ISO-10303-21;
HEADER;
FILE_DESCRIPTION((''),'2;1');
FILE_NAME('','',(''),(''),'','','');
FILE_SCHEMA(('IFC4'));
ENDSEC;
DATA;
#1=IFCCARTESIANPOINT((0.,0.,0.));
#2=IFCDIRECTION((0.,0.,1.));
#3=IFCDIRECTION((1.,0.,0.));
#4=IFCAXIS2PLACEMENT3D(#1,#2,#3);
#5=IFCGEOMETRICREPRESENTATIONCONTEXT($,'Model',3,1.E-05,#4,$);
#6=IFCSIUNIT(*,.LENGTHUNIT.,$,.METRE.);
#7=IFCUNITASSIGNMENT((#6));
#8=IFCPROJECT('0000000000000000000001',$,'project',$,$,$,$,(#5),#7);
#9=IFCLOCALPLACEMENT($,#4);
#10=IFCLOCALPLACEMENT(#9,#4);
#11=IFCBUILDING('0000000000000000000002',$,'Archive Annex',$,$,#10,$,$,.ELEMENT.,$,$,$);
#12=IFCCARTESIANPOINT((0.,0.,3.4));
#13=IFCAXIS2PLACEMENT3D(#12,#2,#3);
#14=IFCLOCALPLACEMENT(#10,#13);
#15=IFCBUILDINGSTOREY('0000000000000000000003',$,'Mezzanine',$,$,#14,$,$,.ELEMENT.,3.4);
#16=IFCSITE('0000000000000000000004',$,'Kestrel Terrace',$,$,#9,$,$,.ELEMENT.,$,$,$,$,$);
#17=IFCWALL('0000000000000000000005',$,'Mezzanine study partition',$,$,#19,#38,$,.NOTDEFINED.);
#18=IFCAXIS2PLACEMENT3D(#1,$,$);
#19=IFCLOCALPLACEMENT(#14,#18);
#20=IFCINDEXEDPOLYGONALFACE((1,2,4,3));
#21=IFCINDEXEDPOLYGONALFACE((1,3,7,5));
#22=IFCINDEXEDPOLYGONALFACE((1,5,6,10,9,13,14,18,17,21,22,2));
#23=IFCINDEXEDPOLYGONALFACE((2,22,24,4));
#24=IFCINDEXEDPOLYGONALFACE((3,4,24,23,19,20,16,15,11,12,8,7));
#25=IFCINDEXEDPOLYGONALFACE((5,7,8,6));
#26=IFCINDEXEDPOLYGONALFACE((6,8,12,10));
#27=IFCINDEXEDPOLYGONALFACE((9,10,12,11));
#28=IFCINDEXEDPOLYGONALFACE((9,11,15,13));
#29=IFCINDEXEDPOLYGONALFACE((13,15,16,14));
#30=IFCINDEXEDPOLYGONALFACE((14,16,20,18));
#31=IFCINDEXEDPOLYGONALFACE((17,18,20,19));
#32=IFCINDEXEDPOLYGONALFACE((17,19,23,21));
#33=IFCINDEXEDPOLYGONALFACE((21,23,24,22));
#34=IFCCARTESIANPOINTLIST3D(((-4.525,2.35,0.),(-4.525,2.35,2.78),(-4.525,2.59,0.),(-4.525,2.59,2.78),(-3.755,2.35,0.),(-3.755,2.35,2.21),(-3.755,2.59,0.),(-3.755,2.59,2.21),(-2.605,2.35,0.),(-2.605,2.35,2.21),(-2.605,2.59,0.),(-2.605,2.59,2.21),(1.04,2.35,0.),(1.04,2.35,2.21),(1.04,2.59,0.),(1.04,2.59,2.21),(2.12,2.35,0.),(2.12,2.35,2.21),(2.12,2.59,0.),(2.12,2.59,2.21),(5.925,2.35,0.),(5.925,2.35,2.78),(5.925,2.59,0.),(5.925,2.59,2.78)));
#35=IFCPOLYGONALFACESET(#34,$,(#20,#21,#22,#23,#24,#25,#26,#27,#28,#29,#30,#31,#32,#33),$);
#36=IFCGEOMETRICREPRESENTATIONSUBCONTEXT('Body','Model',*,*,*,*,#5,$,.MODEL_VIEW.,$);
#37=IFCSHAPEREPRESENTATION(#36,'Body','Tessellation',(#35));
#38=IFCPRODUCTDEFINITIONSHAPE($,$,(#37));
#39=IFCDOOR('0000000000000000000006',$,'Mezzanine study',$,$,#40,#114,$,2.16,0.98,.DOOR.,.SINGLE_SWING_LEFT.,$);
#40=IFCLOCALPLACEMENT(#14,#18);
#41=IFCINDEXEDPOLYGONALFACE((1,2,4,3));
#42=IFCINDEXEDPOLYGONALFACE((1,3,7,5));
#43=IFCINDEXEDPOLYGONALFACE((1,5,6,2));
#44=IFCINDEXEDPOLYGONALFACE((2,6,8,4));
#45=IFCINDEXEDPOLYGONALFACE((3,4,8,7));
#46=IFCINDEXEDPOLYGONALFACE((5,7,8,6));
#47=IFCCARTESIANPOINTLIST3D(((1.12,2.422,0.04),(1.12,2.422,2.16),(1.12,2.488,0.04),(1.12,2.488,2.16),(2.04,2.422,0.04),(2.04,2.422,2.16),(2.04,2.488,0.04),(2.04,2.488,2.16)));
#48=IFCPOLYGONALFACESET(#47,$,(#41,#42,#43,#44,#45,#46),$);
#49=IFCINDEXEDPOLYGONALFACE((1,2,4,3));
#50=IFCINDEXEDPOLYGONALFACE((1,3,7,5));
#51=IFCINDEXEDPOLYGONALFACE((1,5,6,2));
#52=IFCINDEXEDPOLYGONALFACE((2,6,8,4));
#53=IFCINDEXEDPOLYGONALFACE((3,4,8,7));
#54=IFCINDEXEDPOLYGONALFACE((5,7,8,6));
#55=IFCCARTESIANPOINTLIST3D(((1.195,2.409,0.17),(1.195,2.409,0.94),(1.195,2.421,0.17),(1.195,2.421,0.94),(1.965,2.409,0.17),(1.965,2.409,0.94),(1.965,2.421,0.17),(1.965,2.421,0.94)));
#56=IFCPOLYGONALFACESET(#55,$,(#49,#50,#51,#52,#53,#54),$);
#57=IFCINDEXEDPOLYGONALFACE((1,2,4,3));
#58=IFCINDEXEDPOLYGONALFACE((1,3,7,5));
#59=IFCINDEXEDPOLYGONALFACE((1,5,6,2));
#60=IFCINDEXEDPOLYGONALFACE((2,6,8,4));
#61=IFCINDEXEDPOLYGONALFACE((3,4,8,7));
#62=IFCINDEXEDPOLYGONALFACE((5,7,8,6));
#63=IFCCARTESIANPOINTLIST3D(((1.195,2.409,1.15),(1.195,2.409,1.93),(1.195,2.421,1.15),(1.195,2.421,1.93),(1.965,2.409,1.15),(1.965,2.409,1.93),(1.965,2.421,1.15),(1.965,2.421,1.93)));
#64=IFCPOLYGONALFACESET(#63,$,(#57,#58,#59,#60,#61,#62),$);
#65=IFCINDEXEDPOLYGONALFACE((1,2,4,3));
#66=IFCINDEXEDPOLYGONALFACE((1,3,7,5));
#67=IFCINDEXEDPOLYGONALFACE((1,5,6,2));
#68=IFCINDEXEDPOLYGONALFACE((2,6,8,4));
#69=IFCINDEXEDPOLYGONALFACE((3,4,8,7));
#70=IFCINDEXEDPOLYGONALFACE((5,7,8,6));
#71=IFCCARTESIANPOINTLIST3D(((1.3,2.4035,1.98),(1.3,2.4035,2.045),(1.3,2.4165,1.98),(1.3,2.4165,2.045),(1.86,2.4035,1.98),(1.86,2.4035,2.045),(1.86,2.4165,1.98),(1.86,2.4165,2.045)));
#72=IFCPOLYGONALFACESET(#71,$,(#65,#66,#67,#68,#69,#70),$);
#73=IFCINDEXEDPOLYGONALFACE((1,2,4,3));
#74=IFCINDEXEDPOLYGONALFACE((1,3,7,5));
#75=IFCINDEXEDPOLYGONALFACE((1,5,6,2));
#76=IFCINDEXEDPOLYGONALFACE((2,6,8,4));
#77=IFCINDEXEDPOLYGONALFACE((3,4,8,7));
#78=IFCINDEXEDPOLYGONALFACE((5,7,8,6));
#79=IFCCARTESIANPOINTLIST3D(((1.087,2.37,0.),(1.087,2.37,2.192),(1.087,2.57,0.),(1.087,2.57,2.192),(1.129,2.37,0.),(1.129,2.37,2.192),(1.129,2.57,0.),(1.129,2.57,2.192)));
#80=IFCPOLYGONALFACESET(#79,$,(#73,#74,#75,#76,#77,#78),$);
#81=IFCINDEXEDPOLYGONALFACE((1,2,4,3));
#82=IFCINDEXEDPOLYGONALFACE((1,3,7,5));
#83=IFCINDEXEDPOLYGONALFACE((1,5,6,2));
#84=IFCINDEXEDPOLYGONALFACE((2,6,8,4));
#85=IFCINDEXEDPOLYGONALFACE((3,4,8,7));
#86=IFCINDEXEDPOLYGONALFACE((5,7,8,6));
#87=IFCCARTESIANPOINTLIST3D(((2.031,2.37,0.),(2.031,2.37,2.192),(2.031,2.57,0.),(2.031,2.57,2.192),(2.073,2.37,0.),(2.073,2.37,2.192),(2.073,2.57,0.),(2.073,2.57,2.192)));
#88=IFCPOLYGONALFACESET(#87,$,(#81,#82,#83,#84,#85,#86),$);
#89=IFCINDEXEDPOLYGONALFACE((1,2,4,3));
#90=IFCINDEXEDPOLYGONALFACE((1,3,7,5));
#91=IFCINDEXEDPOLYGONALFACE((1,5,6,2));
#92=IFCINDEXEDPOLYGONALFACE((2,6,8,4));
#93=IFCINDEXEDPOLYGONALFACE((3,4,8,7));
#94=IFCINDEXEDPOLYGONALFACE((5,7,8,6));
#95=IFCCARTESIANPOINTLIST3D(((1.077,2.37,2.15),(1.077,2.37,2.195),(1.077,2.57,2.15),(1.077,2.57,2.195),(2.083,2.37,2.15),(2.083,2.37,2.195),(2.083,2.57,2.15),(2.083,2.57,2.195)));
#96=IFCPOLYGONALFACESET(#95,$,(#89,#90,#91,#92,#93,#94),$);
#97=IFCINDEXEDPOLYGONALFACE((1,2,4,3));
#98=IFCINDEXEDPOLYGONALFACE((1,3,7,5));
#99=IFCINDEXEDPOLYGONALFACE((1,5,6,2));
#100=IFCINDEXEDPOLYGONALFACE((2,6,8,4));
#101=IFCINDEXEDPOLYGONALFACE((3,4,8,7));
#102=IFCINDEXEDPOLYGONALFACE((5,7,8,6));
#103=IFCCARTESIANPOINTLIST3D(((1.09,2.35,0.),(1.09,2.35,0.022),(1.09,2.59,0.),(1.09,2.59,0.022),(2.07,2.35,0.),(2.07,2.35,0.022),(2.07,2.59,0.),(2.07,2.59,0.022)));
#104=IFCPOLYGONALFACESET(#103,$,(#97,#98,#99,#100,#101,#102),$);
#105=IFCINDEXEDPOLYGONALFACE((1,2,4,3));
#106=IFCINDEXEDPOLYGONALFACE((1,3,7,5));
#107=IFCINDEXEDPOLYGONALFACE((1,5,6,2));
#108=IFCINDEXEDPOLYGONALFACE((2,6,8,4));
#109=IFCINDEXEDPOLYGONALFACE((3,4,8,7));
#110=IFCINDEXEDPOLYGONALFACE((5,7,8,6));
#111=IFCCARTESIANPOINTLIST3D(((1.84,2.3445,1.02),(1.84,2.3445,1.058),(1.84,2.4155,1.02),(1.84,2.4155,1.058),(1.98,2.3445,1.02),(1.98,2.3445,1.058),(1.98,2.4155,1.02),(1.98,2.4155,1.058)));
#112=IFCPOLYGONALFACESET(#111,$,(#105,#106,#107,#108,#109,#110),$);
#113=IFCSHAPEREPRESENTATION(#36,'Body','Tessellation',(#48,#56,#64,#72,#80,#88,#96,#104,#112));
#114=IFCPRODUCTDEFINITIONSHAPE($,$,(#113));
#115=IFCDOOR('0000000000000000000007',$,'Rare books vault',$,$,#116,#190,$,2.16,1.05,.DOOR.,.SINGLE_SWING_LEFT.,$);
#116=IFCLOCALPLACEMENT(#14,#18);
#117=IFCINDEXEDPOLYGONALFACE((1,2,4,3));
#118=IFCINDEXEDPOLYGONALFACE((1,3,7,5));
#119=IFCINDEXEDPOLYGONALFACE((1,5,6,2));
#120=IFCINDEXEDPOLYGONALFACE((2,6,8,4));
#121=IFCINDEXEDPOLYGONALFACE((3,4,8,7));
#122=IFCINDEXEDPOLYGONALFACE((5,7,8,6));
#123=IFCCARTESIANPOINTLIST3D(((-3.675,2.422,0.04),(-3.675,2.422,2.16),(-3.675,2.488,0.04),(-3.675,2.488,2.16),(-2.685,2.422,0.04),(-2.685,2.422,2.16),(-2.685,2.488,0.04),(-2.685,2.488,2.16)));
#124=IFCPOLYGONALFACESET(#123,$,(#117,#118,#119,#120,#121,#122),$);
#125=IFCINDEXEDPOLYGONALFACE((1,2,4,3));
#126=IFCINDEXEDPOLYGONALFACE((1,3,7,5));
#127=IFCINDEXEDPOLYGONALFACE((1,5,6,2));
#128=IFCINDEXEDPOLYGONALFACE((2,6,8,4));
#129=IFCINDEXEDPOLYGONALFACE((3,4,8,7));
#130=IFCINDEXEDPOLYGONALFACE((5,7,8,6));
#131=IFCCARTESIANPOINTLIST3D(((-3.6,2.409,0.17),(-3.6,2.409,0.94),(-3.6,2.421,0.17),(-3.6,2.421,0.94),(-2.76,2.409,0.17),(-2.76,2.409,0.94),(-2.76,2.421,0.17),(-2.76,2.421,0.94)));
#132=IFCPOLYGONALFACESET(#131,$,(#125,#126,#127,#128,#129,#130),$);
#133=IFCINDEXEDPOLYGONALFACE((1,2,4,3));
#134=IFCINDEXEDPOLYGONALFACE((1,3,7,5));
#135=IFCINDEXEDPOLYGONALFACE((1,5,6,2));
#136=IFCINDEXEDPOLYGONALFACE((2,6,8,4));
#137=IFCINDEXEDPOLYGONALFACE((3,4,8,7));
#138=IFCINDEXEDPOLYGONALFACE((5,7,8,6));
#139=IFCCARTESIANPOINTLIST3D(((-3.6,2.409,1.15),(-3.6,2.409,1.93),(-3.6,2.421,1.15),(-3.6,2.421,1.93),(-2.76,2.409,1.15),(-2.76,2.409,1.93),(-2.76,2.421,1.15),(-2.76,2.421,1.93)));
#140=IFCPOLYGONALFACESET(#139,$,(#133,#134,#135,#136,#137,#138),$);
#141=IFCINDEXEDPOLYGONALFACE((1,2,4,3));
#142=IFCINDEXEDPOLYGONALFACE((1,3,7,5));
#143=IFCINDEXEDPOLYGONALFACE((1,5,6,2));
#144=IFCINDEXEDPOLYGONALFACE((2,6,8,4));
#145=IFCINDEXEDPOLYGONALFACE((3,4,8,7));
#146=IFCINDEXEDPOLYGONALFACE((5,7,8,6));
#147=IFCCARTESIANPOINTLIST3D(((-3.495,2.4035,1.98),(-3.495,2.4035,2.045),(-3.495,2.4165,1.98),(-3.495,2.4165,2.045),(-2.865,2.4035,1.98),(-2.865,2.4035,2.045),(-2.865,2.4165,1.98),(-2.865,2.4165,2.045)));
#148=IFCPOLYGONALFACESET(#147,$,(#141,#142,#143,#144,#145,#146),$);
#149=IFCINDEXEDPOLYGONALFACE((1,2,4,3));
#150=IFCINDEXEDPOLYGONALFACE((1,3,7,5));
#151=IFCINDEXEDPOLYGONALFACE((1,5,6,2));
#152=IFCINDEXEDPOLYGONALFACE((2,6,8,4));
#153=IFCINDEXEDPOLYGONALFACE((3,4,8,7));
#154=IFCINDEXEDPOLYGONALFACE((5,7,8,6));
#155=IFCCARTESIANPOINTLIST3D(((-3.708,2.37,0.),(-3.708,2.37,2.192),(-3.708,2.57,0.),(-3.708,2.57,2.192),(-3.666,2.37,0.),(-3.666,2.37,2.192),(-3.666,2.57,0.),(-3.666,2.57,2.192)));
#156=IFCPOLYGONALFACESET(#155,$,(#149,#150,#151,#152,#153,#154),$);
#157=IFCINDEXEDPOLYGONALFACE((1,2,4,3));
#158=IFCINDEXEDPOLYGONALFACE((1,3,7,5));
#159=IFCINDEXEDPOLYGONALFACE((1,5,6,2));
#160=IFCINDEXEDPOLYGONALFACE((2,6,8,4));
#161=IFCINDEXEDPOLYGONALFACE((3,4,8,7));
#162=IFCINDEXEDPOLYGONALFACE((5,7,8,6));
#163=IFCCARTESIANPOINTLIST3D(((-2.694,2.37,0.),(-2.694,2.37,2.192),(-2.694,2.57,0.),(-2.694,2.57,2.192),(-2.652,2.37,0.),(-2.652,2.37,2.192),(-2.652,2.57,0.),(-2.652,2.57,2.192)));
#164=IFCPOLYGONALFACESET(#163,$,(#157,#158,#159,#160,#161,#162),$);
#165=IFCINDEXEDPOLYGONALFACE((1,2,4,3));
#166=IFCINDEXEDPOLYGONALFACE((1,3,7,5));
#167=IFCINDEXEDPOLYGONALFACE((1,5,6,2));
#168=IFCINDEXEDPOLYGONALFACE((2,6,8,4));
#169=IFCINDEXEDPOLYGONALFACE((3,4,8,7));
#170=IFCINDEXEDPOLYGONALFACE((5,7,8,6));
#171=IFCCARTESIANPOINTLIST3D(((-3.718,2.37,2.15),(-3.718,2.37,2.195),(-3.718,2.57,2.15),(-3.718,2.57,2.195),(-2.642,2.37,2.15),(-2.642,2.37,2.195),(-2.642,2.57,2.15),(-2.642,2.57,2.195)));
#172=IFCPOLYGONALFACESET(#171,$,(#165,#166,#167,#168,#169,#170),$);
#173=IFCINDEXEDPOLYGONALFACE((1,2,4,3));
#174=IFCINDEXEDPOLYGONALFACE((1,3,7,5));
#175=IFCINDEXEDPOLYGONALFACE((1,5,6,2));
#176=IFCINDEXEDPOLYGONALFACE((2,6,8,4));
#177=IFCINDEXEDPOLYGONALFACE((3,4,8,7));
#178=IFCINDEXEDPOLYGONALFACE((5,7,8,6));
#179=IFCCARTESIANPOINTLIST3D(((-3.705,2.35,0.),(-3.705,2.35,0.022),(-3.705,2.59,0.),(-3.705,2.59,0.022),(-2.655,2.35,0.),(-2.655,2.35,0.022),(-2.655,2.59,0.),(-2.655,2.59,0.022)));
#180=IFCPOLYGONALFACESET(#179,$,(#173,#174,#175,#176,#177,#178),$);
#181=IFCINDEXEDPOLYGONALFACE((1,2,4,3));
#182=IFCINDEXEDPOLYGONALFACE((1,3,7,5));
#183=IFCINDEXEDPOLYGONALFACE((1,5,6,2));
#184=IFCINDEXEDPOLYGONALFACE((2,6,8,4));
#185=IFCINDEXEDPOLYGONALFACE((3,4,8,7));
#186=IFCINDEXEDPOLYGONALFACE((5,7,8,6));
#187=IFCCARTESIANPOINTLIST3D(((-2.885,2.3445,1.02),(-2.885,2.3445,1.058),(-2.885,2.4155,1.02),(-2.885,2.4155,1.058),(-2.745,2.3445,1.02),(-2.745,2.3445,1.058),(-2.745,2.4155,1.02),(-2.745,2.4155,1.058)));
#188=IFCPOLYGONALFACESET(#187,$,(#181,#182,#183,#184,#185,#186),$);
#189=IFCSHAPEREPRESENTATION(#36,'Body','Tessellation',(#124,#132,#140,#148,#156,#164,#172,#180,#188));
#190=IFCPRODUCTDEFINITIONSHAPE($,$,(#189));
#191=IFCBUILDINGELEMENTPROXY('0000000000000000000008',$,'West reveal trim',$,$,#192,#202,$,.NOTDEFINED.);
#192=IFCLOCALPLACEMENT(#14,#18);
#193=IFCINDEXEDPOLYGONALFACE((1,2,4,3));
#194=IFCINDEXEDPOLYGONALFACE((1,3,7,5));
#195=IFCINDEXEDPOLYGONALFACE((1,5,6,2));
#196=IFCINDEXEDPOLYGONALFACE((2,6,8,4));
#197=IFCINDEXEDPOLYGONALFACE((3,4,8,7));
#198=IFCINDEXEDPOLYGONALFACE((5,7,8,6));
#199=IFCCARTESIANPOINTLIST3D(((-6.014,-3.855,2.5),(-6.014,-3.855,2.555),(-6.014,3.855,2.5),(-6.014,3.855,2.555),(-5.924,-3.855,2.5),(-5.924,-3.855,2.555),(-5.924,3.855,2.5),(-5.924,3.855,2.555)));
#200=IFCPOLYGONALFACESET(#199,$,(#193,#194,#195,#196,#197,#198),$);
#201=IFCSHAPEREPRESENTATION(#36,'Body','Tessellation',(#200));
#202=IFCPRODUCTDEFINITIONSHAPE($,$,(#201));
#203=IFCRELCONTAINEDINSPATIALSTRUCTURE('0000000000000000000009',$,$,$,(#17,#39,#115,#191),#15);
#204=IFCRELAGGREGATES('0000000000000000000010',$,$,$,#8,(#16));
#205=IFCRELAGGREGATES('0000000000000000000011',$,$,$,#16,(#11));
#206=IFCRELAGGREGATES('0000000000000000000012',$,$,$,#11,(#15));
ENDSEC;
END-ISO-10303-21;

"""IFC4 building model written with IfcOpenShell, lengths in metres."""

from ifc_helpers import new_model, si_unit, frame, origin_with_axes, origin_2d, place, context, subcontext, project, spatial, rectangle, extrude, element, fill, save


model = new_model("IFC4")

# Units and contexts
model_context = context("Model", 3, precision=1e-05, world=origin_with_axes())
body_context = subcontext(model_context, "Body", "Model", "MODEL_VIEW")
ifc_project = project(units=[si_unit("LENGTHUNIT", "METRE")], contexts=[model_context])

# Site, building, storey
site_placement = place(None, origin_with_axes())
site = spatial("IfcSite", under=ifc_project, at=site_placement, Name="Kestrel Terrace", CompositionType="ELEMENT")
building_placement = place(site_placement, origin_with_axes())
building = spatial("IfcBuilding", under=site, at=building_placement, Name="Archive Annex", CompositionType="ELEMENT")
storey_placement = place(building_placement, frame((0.0, 0.0, 3.4), z_axis=(0.0, 0.0, 1.0), x_axis=(1.0, 0.0, 0.0)))
storey = spatial("IfcBuildingStorey", under=building, at=storey_placement, Name="Mezzanine", CompositionType="ELEMENT", Elevation=3.4)

# Wall, openings, doors
wall_1_placement = place(storey_placement, frame((0.7, 2.47, 0.0), z_axis=(0.0, 0.0, 1.0), x_axis=(1.0, 0.0, 0.0)))
wall_1 = element("IfcWall", 1, at=wall_1_placement, inside=storey, Name="Mezzanine study partition", PredefinedType="NOTDEFINED", context=body_context, shape_type="SweptSolid", body=[
    extrude(rectangle(XDim=10.45, YDim=0.24, at=origin_2d()), origin_with_axes(), (0.0, 0.0, 1.0), 2.78),
])
opening_1_placement = place(wall_1_placement, frame((0.88, 0.0, 0.0), z_axis=(0.0, 0.0, 1.0), x_axis=(1.0, 0.0, 0.0)))
opening_1 = element("IfcOpeningElement", 2, at=opening_1_placement, cuts=wall_1, PredefinedType="OPENING", context=body_context, shape_type="SweptSolid", body=[
    extrude(rectangle(XDim=1.08, YDim=0.58, at=origin_2d()), origin_with_axes(), (0.0, 0.0, 1.0), 2.21),
])
opening_2_placement = place(wall_1_placement, frame((-3.88, 0.0, 0.0), z_axis=(0.0, 0.0, 1.0), x_axis=(1.0, 0.0, 0.0)))
opening_2 = element("IfcOpeningElement", 3, at=opening_2_placement, cuts=wall_1, PredefinedType="OPENING", context=body_context, shape_type="SweptSolid", body=[
    extrude(rectangle(XDim=1.15, YDim=0.58, at=origin_2d()), origin_with_axes(), (0.0, 0.0, 1.0), 2.21),
])
door_1_placement = place(opening_1_placement, origin_with_axes())
door_1 = element("IfcDoor", 4, at=door_1_placement, inside=storey, Name="Mezzanine study", OperationType="SINGLE_SWING_LEFT", OverallHeight=2.16, OverallWidth=0.98, PredefinedType="DOOR", context=body_context, shape_type="SweptSolid", body=[
    extrude(rectangle(XDim=0.92, YDim=0.066, at=origin_2d()), frame((0.0, -0.015, 0.04), z_axis=(0.0, 0.0, 1.0), x_axis=(1.0, 0.0, 0.0)), (0.0, 0.0, 1.0), 2.12),
    extrude(rectangle(XDim=0.77, YDim=0.012, at=origin_2d()), frame((0.0, -0.055, 0.17), z_axis=(0.0, 0.0, 1.0), x_axis=(1.0, 0.0, 0.0)), (0.0, 0.0, 1.0), 0.77),
    extrude(rectangle(XDim=0.77, YDim=0.012, at=origin_2d()), frame((0.0, -0.055, 1.15), z_axis=(0.0, 0.0, 1.0), x_axis=(1.0, 0.0, 0.0)), (0.0, 0.0, 1.0), 0.78),
    extrude(rectangle(XDim=0.56, YDim=0.013, at=origin_2d()), frame((0.0, -0.06, 1.98), z_axis=(0.0, 0.0, 1.0), x_axis=(1.0, 0.0, 0.0)), (0.0, 0.0, 1.0), 0.065),
    extrude(rectangle(XDim=0.042, YDim=0.2, at=origin_2d()), frame((-0.472, 0.0, 0.0), z_axis=(0.0, 0.0, 1.0), x_axis=(1.0, 0.0, 0.0)), (0.0, 0.0, 1.0), 2.192),
    extrude(rectangle(XDim=0.042, YDim=0.2, at=origin_2d()), frame((0.472, 0.0, 0.0), z_axis=(0.0, 0.0, 1.0), x_axis=(1.0, 0.0, 0.0)), (0.0, 0.0, 1.0), 2.192),
    extrude(rectangle(XDim=1.006, YDim=0.2, at=origin_2d()), frame((0.0, 0.0, 2.15), z_axis=(0.0, 0.0, 1.0), x_axis=(1.0, 0.0, 0.0)), (0.0, 0.0, 1.0), 0.045),
    extrude(rectangle(XDim=0.98, YDim=0.24, at=origin_2d()), origin_with_axes(), (0.0, 0.0, 1.0), 0.022),
    extrude(rectangle(XDim=0.14, YDim=0.071, at=origin_2d()), frame((0.33, -0.09, 1.02), z_axis=(0.0, 0.0, 1.0), x_axis=(1.0, 0.0, 0.0)), (0.0, 0.0, 1.0), 0.038),
])
fill(opening_1, door_1)
door_2_placement = place(opening_2_placement, origin_with_axes())
door_2 = element("IfcDoor", 5, at=door_2_placement, inside=storey, Name="Rare books vault", OperationType="SINGLE_SWING_LEFT", OverallHeight=2.16, OverallWidth=1.05, PredefinedType="DOOR", context=body_context, shape_type="SweptSolid", body=[
    extrude(rectangle(XDim=0.99, YDim=0.066, at=origin_2d()), frame((0.0, -0.015, 0.04), z_axis=(0.0, 0.0, 1.0), x_axis=(1.0, 0.0, 0.0)), (0.0, 0.0, 1.0), 2.12),
    extrude(rectangle(XDim=0.84, YDim=0.012, at=origin_2d()), frame((0.0, -0.055, 0.17), z_axis=(0.0, 0.0, 1.0), x_axis=(1.0, 0.0, 0.0)), (0.0, 0.0, 1.0), 0.77),
    extrude(rectangle(XDim=0.84, YDim=0.012, at=origin_2d()), frame((0.0, -0.055, 1.15), z_axis=(0.0, 0.0, 1.0), x_axis=(1.0, 0.0, 0.0)), (0.0, 0.0, 1.0), 0.78),
    extrude(rectangle(XDim=0.63, YDim=0.013, at=origin_2d()), frame((0.0, -0.06, 1.98), z_axis=(0.0, 0.0, 1.0), x_axis=(1.0, 0.0, 0.0)), (0.0, 0.0, 1.0), 0.065),
    extrude(rectangle(XDim=0.042, YDim=0.2, at=origin_2d()), frame((-0.507, 0.0, 0.0), z_axis=(0.0, 0.0, 1.0), x_axis=(1.0, 0.0, 0.0)), (0.0, 0.0, 1.0), 2.192),
    extrude(rectangle(XDim=0.042, YDim=0.2, at=origin_2d()), frame((0.507, 0.0, 0.0), z_axis=(0.0, 0.0, 1.0), x_axis=(1.0, 0.0, 0.0)), (0.0, 0.0, 1.0), 2.192),
    extrude(rectangle(XDim=1.076, YDim=0.2, at=origin_2d()), frame((0.0, 0.0, 2.15), z_axis=(0.0, 0.0, 1.0), x_axis=(1.0, 0.0, 0.0)), (0.0, 0.0, 1.0), 0.045),
    extrude(rectangle(XDim=1.05, YDim=0.24, at=origin_2d()), origin_with_axes(), (0.0, 0.0, 1.0), 0.022),
    extrude(rectangle(XDim=0.14, YDim=0.071, at=origin_2d()), frame((0.365, -0.09, 1.02), z_axis=(0.0, 0.0, 1.0), x_axis=(1.0, 0.0, 0.0)), (0.0, 0.0, 1.0), 0.038),
])
fill(opening_2, door_2)

# Building element proxy
proxy_1_placement = place(storey_placement, origin_with_axes())
element("IfcBuildingElementProxy", 6, at=proxy_1_placement, inside=storey, Name="West reveal trim", PredefinedType="NOTDEFINED", context=body_context, shape_type="SweptSolid", body=[
    extrude(rectangle(XDim=0.09, YDim=7.71, at=origin_2d()), frame((-5.969, 0.0, 2.5), z_axis=(0.0, 0.0, 1.0), x_axis=(1.0, 0.0, 0.0)), (0.0, 0.0, 1.0), 0.055),
])

save(model, "model.ifc")
